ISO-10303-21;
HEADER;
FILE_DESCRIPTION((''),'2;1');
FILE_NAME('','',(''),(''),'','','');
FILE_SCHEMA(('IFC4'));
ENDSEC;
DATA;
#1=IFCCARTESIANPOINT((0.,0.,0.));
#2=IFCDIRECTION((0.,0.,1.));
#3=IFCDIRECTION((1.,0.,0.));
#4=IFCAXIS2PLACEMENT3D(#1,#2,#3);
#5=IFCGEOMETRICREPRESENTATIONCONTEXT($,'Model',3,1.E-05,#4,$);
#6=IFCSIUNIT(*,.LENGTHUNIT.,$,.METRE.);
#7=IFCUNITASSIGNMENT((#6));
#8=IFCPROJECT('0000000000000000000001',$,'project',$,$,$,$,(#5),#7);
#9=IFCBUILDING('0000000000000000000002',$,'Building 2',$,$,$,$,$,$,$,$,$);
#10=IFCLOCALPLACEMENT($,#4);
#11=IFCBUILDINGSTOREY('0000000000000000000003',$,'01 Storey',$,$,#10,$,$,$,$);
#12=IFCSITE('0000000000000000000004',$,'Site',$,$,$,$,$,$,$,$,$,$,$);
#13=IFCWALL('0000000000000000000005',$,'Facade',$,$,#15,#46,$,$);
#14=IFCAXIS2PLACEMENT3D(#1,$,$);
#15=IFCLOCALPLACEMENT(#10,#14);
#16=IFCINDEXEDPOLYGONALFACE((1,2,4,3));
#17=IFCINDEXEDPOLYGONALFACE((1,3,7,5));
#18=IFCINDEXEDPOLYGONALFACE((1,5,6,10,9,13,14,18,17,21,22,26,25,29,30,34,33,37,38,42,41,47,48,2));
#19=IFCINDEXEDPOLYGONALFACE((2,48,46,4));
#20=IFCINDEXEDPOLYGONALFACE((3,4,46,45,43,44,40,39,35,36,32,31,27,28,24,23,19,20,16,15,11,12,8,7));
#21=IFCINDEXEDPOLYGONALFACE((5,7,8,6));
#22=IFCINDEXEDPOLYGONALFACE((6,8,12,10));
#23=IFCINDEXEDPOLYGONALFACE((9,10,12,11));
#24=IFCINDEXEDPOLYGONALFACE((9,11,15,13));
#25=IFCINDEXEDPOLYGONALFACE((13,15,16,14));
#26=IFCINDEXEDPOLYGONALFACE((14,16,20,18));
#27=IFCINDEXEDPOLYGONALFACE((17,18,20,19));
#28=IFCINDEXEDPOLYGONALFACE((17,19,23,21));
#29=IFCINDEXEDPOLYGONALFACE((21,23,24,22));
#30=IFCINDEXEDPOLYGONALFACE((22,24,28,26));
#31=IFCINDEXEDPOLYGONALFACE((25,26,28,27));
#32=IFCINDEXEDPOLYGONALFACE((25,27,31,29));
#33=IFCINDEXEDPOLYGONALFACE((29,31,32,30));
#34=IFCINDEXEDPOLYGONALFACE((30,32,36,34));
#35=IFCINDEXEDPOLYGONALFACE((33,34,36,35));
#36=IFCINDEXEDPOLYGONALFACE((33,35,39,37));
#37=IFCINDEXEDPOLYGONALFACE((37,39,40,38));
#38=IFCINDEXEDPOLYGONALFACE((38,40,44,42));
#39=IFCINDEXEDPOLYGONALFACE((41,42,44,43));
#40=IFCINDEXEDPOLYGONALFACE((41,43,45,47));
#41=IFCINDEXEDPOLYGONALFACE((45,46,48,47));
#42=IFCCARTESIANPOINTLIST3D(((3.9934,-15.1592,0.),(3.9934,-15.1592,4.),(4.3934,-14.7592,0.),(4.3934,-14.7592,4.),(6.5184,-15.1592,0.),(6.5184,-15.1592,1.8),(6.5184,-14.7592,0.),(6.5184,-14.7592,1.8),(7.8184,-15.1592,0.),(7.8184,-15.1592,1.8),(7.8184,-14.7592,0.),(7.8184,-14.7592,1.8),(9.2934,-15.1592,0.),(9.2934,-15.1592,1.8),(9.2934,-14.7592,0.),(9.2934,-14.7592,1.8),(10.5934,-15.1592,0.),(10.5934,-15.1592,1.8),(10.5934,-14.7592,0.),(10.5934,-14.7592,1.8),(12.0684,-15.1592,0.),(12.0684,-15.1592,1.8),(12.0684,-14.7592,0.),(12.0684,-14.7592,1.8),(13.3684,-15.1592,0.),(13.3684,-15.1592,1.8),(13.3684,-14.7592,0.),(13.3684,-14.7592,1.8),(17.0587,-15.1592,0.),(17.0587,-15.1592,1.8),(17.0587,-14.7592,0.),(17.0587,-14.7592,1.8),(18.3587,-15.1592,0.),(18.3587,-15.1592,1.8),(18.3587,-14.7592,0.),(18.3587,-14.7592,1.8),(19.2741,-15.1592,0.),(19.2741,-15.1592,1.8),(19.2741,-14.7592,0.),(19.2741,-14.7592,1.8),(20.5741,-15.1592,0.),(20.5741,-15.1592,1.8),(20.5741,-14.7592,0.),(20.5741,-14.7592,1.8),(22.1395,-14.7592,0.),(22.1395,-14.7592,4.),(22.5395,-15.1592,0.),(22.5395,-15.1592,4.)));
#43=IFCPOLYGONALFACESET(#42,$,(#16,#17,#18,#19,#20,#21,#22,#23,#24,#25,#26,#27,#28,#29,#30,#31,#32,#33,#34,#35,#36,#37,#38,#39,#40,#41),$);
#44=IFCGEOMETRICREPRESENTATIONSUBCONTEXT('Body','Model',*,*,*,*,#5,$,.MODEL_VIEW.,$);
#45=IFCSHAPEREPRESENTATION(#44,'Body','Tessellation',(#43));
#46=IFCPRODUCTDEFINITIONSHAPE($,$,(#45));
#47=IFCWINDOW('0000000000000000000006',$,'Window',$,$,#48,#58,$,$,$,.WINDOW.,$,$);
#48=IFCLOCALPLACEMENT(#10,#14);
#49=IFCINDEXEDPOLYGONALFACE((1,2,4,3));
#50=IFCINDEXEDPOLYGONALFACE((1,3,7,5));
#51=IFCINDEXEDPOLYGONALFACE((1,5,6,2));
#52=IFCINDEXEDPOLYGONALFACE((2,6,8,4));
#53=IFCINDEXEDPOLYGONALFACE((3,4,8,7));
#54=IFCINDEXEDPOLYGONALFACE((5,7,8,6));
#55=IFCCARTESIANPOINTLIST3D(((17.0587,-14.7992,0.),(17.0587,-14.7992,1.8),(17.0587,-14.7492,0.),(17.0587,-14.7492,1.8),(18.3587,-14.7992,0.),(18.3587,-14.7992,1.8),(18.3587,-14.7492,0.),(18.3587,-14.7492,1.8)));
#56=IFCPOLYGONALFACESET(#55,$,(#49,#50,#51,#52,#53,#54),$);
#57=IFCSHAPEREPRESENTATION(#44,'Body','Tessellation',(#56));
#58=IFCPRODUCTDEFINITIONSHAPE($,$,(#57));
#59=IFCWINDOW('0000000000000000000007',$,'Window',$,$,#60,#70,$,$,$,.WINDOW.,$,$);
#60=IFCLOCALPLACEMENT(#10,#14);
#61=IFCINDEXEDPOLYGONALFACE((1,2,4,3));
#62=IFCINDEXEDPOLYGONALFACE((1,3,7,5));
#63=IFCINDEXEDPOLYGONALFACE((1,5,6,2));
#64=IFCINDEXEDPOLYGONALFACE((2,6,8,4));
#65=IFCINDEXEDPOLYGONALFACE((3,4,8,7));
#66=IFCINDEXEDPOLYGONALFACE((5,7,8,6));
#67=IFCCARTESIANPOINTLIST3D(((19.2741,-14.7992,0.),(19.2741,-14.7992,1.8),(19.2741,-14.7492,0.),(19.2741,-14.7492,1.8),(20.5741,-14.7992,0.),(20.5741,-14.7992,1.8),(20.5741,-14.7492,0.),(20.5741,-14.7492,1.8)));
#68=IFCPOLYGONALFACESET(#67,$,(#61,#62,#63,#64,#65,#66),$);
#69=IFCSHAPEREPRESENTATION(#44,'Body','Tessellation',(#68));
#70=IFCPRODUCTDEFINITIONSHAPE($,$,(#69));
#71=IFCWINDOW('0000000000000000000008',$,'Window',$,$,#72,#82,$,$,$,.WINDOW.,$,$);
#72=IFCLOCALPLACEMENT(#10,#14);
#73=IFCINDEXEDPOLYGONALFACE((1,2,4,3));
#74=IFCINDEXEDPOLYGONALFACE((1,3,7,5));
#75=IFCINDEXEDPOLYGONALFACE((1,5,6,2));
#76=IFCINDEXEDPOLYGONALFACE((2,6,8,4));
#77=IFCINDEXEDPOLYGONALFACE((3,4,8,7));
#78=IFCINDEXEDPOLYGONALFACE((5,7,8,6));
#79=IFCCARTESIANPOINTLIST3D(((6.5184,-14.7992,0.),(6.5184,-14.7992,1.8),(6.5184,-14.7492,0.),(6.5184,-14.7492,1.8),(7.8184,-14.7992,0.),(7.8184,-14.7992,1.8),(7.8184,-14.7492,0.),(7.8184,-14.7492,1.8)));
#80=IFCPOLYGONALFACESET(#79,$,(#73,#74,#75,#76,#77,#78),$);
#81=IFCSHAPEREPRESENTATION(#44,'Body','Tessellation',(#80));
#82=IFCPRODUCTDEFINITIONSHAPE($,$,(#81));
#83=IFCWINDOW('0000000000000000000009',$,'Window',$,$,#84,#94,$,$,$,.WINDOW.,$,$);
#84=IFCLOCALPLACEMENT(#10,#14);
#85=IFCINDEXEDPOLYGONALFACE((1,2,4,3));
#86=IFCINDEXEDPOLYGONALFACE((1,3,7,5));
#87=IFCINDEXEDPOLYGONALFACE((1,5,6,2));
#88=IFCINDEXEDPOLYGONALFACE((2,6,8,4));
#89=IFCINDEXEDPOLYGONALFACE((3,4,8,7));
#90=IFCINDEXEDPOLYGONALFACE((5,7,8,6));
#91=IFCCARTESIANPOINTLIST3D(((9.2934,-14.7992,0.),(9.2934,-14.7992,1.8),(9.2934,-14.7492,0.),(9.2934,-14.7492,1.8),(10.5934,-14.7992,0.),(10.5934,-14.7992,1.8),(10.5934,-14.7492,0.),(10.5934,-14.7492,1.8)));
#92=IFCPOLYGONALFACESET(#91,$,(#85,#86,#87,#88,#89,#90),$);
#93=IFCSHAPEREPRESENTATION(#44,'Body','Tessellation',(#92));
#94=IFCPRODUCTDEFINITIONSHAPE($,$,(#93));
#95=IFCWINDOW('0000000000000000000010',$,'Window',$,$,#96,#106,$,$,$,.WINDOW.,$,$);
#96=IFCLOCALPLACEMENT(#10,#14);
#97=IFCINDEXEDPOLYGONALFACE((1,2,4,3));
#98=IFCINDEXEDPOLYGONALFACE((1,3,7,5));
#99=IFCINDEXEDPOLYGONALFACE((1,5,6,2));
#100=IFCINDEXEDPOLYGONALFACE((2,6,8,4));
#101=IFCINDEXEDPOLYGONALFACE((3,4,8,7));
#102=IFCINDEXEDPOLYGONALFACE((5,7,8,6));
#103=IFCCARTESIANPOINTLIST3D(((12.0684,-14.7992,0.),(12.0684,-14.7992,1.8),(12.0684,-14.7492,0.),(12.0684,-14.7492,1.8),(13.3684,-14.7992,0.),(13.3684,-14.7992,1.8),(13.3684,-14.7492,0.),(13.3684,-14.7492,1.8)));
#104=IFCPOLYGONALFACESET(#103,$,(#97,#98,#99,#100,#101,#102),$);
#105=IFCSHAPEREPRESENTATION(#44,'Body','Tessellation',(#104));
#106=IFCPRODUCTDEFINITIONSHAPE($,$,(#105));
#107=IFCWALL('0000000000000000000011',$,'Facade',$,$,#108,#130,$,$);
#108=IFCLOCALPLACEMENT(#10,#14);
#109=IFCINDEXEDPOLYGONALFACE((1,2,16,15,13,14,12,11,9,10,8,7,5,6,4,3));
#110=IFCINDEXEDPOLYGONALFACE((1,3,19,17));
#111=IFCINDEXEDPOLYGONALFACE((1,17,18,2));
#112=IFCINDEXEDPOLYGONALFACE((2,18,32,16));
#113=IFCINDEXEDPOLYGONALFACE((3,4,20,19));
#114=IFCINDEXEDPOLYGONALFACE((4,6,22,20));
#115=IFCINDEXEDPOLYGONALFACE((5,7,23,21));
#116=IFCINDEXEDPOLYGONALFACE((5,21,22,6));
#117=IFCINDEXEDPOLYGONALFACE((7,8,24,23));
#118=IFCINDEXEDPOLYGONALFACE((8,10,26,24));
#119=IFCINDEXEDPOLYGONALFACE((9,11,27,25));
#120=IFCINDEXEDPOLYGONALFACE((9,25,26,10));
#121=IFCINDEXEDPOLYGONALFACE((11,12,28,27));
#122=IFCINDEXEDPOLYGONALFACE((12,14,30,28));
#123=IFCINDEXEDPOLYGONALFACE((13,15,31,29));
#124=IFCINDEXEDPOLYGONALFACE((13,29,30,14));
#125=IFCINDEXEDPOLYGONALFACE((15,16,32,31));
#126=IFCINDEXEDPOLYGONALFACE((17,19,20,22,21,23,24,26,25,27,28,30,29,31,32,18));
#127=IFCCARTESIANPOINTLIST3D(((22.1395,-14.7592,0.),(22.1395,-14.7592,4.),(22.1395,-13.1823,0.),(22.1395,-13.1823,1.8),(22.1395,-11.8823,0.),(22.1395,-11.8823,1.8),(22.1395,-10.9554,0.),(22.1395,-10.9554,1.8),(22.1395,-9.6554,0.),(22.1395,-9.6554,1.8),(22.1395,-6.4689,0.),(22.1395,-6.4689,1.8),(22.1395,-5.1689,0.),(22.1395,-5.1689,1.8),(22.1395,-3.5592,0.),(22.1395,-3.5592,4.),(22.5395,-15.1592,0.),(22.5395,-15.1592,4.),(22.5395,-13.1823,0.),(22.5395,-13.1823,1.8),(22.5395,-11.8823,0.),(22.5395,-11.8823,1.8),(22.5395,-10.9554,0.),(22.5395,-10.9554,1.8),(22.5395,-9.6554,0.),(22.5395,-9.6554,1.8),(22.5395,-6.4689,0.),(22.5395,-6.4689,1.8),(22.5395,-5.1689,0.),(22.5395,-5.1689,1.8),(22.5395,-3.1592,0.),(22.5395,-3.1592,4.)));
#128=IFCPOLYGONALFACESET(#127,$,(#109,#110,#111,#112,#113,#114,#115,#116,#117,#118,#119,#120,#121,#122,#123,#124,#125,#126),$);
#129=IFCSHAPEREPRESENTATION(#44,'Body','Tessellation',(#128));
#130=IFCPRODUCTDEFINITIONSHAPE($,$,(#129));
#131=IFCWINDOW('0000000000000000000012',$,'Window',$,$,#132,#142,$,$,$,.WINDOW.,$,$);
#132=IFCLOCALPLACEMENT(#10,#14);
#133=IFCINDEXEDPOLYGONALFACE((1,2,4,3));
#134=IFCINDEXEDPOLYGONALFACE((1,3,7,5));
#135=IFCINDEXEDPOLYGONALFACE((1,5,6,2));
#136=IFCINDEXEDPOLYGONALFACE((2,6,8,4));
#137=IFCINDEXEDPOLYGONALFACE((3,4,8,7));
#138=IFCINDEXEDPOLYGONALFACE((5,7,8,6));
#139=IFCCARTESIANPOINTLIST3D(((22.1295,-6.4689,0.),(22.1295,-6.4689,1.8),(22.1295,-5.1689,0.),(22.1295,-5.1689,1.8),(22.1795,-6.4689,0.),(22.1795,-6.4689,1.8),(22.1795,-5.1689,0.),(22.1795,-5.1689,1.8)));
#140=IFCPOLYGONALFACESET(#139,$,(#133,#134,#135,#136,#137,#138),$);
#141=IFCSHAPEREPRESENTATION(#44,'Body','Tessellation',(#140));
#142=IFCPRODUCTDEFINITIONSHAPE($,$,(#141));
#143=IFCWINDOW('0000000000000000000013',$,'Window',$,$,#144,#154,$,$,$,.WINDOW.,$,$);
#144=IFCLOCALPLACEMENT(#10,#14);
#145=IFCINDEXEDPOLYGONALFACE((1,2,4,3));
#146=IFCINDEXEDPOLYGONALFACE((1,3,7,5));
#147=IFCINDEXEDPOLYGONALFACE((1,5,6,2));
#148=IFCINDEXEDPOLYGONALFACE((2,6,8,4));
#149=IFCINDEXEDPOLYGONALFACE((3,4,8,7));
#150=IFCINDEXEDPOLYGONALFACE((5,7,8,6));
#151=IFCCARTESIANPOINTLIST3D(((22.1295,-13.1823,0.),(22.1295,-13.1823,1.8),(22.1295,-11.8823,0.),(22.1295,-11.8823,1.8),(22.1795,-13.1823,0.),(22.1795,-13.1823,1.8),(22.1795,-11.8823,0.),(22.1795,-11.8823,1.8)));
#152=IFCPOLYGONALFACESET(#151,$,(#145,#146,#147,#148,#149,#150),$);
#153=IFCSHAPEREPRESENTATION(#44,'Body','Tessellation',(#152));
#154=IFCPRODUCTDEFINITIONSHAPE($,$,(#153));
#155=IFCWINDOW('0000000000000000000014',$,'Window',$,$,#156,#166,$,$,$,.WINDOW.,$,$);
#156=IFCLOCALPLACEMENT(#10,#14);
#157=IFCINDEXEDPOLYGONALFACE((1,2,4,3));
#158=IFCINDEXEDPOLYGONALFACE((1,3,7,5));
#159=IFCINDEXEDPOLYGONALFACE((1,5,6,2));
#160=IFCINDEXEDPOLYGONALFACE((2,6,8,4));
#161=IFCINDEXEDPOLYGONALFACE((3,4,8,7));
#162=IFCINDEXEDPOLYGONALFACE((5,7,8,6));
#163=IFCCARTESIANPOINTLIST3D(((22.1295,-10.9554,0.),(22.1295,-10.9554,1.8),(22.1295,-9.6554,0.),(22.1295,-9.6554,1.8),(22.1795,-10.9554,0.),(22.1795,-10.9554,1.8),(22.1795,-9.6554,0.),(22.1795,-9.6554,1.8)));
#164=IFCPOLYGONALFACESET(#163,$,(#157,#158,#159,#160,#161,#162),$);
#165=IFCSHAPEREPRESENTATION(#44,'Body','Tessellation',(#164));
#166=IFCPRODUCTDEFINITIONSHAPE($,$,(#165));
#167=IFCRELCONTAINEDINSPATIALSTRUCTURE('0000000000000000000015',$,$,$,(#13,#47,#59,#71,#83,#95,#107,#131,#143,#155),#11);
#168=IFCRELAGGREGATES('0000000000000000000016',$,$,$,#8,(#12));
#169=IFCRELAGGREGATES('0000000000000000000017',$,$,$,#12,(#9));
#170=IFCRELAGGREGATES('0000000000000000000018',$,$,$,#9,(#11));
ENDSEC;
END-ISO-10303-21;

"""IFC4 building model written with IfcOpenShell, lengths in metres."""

from ifc_helpers import new_model, si_unit, origin_with_axes, place, context, subcontext, project, spatial, line, indexed_curve, outline, extrude, element, fill, save


model = new_model("IFC4")

# Units and contexts
model_context = context("Model", 3, precision=1e-05, world=origin_with_axes())
body_context = subcontext(model_context, "Body", "Model", "MODEL_VIEW")
ifc_project = project(units=[si_unit("LENGTHUNIT", "METRE")], contexts=[model_context])

# Site, building, storey
site = spatial("IfcSite", under=ifc_project, Name="Site")
building = spatial("IfcBuilding", under=site, Name="Building 2")
storey_placement = place(None, origin_with_axes())
storey = spatial("IfcBuildingStorey", under=building, at=storey_placement, Name="01 Storey")

# Walls, openings, windows
wall_1_placement = place(storey_placement, origin_with_axes())
wall_1 = element("IfcWall", 1, at=wall_1_placement, inside=storey, Name="Facade", context=body_context, shape_type="SweptSolid", body=[
    extrude(outline(indexed_curve([(4.3934, -14.7592), (22.1395, -14.7592), (22.5395, -15.1592), (3.9934, -15.1592)], segments=[line(1, 2), line(2, 3), line(3, 4)])), origin_with_axes(), (0.0, 0.0, 1.0), 4.0),
])
opening_1_placement = place(wall_1_placement, origin_with_axes())
opening_1 = element("IfcOpeningElement", 2, at=opening_1_placement, cuts=wall_1, context=body_context, shape_type="SweptSolid", body=[
    extrude(outline(indexed_curve([(17.0587, -15.1992), (17.0587, -14.6992), (18.3587, -14.6992), (18.3587, -15.1992)], segments=[line(1, 2), line(2, 3), line(3, 4)])), origin_with_axes(), (0.0, 0.0, 1.0), 1.8),
])
opening_2_placement = place(wall_1_placement, origin_with_axes())
opening_2 = element("IfcOpeningElement", 3, at=opening_2_placement, cuts=wall_1, context=body_context, shape_type="SweptSolid", body=[
    extrude(outline(indexed_curve([(19.2741, -15.1992), (19.2741, -14.6992), (20.5741, -14.6992), (20.5741, -15.1992)], segments=[line(1, 2), line(2, 3), line(3, 4)])), origin_with_axes(), (0.0, 0.0, 1.0), 1.8),
])
opening_3_placement = place(wall_1_placement, origin_with_axes())
opening_3 = element("IfcOpeningElement", 4, at=opening_3_placement, cuts=wall_1, context=body_context, shape_type="SweptSolid", body=[
    extrude(outline(indexed_curve([(6.5184, -15.1992), (6.5184, -14.6992), (7.8184, -14.6992), (7.8184, -15.1992)], segments=[line(1, 2), line(2, 3), line(3, 4)])), origin_with_axes(), (0.0, 0.0, 1.0), 1.8),
])
opening_4_placement = place(wall_1_placement, origin_with_axes())
opening_4 = element("IfcOpeningElement", 5, at=opening_4_placement, cuts=wall_1, context=body_context, shape_type="SweptSolid", body=[
    extrude(outline(indexed_curve([(9.2934, -15.1992), (9.2934, -14.6992), (10.5934, -14.6992), (10.5934, -15.1992)], segments=[line(1, 2), line(2, 3), line(3, 4)])), origin_with_axes(), (0.0, 0.0, 1.0), 1.8),
])
opening_5_placement = place(wall_1_placement, origin_with_axes())
opening_5 = element("IfcOpeningElement", 6, at=opening_5_placement, cuts=wall_1, context=body_context, shape_type="SweptSolid", body=[
    extrude(outline(indexed_curve([(12.0684, -15.1992), (12.0684, -14.6992), (13.3684, -14.6992), (13.3684, -15.1992)], segments=[line(1, 2), line(2, 3), line(3, 4)])), origin_with_axes(), (0.0, 0.0, 1.0), 1.8),
])
window_1_placement = place(storey_placement, origin_with_axes())
window_1 = element("IfcWindow", 7, at=window_1_placement, inside=storey, Name="Window", PredefinedType="WINDOW", context=body_context, shape_type="SweptSolid", body=[
    extrude(outline(indexed_curve([(17.0587, -14.7992), (17.0587, -14.7492), (18.3587, -14.7492), (18.3587, -14.7992)], segments=[line(1, 2), line(2, 3), line(3, 4)])), origin_with_axes(), (0.0, 0.0, 1.0), 1.8),
])
fill(opening_1, window_1)
window_2_placement = place(storey_placement, origin_with_axes())
window_2 = element("IfcWindow", 8, at=window_2_placement, inside=storey, Name="Window", PredefinedType="WINDOW", context=body_context, shape_type="SweptSolid", body=[
    extrude(outline(indexed_curve([(19.2741, -14.7992), (19.2741, -14.7492), (20.5741, -14.7492), (20.5741, -14.7992)], segments=[line(1, 2), line(2, 3), line(3, 4)])), origin_with_axes(), (0.0, 0.0, 1.0), 1.8),
])
fill(opening_2, window_2)
window_3_placement = place(storey_placement, origin_with_axes())
window_3 = element("IfcWindow", 9, at=window_3_placement, inside=storey, Name="Window", PredefinedType="WINDOW", context=body_context, shape_type="SweptSolid", body=[
    extrude(outline(indexed_curve([(6.5184, -14.7992), (6.5184, -14.7492), (7.8184, -14.7492), (7.8184, -14.7992)], segments=[line(1, 2), line(2, 3), line(3, 4)])), origin_with_axes(), (0.0, 0.0, 1.0), 1.8),
])
fill(opening_3, window_3)
window_4_placement = place(storey_placement, origin_with_axes())
window_4 = element("IfcWindow", 10, at=window_4_placement, inside=storey, Name="Window", PredefinedType="WINDOW", context=body_context, shape_type="SweptSolid", body=[
    extrude(outline(indexed_curve([(9.2934, -14.7992), (9.2934, -14.7492), (10.5934, -14.7492), (10.5934, -14.7992)], segments=[line(1, 2), line(2, 3), line(3, 4)])), origin_with_axes(), (0.0, 0.0, 1.0), 1.8),
])
fill(opening_4, window_4)
window_5_placement = place(storey_placement, origin_with_axes())
window_5 = element("IfcWindow", 11, at=window_5_placement, inside=storey, Name="Window", PredefinedType="WINDOW", context=body_context, shape_type="SweptSolid", body=[
    extrude(outline(indexed_curve([(12.0684, -14.7992), (12.0684, -14.7492), (13.3684, -14.7492), (13.3684, -14.7992)], segments=[line(1, 2), line(2, 3), line(3, 4)])), origin_with_axes(), (0.0, 0.0, 1.0), 1.8),
])
fill(opening_5, window_5)
wall_2_placement = place(storey_placement, origin_with_axes())
wall_2 = element("IfcWall", 12, at=wall_2_placement, inside=storey, Name="Facade", context=body_context, shape_type="SweptSolid", body=[
    extrude(outline(indexed_curve([(22.1395, -14.7592), (22.1395, -3.5592), (22.5395, -3.1592), (22.5395, -15.1592)], segments=[line(1, 2), line(2, 3), line(3, 4)])), origin_with_axes(), (0.0, 0.0, 1.0), 4.0),
])
opening_6_placement = place(wall_2_placement, origin_with_axes())
opening_6 = element("IfcOpeningElement", 13, at=opening_6_placement, cuts=wall_2, context=body_context, shape_type="SweptSolid", body=[
    extrude(outline(indexed_curve([(22.5795, -6.4689), (22.0795, -6.4689), (22.0795, -5.1689), (22.5795, -5.1689)], segments=[line(1, 2), line(2, 3), line(3, 4)])), origin_with_axes(), (0.0, 0.0, 1.0), 1.8),
])
opening_7_placement = place(wall_2_placement, origin_with_axes())
opening_7 = element("IfcOpeningElement", 14, at=opening_7_placement, cuts=wall_2, context=body_context, shape_type="SweptSolid", body=[
    extrude(outline(indexed_curve([(22.5795, -13.1823), (22.0795, -13.1823), (22.0795, -11.8823), (22.5795, -11.8823)], segments=[line(1, 2), line(2, 3), line(3, 4)])), origin_with_axes(), (0.0, 0.0, 1.0), 1.8),
])
opening_8_placement = place(wall_2_placement, origin_with_axes())
opening_8 = element("IfcOpeningElement", 15, at=opening_8_placement, cuts=wall_2, context=body_context, shape_type="SweptSolid", body=[
    extrude(outline(indexed_curve([(22.5795, -10.9554), (22.0795, -10.9554), (22.0795, -9.6554), (22.5795, -9.6554)], segments=[line(1, 2), line(2, 3), line(3, 4)])), origin_with_axes(), (0.0, 0.0, 1.0), 1.8),
])
window_6_placement = place(storey_placement, origin_with_axes())
window_6 = element("IfcWindow", 16, at=window_6_placement, inside=storey, Name="Window", PredefinedType="WINDOW", context=body_context, shape_type="SweptSolid", body=[
    extrude(outline(indexed_curve([(22.1795, -6.4689), (22.1295, -6.4689), (22.1295, -5.1689), (22.1795, -5.1689)], segments=[line(1, 2), line(2, 3), line(3, 4)])), origin_with_axes(), (0.0, 0.0, 1.0), 1.8),
])
fill(opening_6, window_6)
window_7_placement = place(storey_placement, origin_with_axes())
window_7 = element("IfcWindow", 17, at=window_7_placement, inside=storey, Name="Window", PredefinedType="WINDOW", context=body_context, shape_type="SweptSolid", body=[
    extrude(outline(indexed_curve([(22.1795, -13.1823), (22.1295, -13.1823), (22.1295, -11.8823), (22.1795, -11.8823)], segments=[line(1, 2), line(2, 3), line(3, 4)])), origin_with_axes(), (0.0, 0.0, 1.0), 1.8),
])
fill(opening_7, window_7)
window_8_placement = place(storey_placement, origin_with_axes())
window_8 = element("IfcWindow", 18, at=window_8_placement, inside=storey, Name="Window", PredefinedType="WINDOW", context=body_context, shape_type="SweptSolid", body=[
    extrude(outline(indexed_curve([(22.1795, -10.9554), (22.1295, -10.9554), (22.1295, -9.6554), (22.1795, -9.6554)], segments=[line(1, 2), line(2, 3), line(3, 4)])), origin_with_axes(), (0.0, 0.0, 1.0), 1.8),
])
fill(opening_8, window_8)

save(model, "model.ifc")
